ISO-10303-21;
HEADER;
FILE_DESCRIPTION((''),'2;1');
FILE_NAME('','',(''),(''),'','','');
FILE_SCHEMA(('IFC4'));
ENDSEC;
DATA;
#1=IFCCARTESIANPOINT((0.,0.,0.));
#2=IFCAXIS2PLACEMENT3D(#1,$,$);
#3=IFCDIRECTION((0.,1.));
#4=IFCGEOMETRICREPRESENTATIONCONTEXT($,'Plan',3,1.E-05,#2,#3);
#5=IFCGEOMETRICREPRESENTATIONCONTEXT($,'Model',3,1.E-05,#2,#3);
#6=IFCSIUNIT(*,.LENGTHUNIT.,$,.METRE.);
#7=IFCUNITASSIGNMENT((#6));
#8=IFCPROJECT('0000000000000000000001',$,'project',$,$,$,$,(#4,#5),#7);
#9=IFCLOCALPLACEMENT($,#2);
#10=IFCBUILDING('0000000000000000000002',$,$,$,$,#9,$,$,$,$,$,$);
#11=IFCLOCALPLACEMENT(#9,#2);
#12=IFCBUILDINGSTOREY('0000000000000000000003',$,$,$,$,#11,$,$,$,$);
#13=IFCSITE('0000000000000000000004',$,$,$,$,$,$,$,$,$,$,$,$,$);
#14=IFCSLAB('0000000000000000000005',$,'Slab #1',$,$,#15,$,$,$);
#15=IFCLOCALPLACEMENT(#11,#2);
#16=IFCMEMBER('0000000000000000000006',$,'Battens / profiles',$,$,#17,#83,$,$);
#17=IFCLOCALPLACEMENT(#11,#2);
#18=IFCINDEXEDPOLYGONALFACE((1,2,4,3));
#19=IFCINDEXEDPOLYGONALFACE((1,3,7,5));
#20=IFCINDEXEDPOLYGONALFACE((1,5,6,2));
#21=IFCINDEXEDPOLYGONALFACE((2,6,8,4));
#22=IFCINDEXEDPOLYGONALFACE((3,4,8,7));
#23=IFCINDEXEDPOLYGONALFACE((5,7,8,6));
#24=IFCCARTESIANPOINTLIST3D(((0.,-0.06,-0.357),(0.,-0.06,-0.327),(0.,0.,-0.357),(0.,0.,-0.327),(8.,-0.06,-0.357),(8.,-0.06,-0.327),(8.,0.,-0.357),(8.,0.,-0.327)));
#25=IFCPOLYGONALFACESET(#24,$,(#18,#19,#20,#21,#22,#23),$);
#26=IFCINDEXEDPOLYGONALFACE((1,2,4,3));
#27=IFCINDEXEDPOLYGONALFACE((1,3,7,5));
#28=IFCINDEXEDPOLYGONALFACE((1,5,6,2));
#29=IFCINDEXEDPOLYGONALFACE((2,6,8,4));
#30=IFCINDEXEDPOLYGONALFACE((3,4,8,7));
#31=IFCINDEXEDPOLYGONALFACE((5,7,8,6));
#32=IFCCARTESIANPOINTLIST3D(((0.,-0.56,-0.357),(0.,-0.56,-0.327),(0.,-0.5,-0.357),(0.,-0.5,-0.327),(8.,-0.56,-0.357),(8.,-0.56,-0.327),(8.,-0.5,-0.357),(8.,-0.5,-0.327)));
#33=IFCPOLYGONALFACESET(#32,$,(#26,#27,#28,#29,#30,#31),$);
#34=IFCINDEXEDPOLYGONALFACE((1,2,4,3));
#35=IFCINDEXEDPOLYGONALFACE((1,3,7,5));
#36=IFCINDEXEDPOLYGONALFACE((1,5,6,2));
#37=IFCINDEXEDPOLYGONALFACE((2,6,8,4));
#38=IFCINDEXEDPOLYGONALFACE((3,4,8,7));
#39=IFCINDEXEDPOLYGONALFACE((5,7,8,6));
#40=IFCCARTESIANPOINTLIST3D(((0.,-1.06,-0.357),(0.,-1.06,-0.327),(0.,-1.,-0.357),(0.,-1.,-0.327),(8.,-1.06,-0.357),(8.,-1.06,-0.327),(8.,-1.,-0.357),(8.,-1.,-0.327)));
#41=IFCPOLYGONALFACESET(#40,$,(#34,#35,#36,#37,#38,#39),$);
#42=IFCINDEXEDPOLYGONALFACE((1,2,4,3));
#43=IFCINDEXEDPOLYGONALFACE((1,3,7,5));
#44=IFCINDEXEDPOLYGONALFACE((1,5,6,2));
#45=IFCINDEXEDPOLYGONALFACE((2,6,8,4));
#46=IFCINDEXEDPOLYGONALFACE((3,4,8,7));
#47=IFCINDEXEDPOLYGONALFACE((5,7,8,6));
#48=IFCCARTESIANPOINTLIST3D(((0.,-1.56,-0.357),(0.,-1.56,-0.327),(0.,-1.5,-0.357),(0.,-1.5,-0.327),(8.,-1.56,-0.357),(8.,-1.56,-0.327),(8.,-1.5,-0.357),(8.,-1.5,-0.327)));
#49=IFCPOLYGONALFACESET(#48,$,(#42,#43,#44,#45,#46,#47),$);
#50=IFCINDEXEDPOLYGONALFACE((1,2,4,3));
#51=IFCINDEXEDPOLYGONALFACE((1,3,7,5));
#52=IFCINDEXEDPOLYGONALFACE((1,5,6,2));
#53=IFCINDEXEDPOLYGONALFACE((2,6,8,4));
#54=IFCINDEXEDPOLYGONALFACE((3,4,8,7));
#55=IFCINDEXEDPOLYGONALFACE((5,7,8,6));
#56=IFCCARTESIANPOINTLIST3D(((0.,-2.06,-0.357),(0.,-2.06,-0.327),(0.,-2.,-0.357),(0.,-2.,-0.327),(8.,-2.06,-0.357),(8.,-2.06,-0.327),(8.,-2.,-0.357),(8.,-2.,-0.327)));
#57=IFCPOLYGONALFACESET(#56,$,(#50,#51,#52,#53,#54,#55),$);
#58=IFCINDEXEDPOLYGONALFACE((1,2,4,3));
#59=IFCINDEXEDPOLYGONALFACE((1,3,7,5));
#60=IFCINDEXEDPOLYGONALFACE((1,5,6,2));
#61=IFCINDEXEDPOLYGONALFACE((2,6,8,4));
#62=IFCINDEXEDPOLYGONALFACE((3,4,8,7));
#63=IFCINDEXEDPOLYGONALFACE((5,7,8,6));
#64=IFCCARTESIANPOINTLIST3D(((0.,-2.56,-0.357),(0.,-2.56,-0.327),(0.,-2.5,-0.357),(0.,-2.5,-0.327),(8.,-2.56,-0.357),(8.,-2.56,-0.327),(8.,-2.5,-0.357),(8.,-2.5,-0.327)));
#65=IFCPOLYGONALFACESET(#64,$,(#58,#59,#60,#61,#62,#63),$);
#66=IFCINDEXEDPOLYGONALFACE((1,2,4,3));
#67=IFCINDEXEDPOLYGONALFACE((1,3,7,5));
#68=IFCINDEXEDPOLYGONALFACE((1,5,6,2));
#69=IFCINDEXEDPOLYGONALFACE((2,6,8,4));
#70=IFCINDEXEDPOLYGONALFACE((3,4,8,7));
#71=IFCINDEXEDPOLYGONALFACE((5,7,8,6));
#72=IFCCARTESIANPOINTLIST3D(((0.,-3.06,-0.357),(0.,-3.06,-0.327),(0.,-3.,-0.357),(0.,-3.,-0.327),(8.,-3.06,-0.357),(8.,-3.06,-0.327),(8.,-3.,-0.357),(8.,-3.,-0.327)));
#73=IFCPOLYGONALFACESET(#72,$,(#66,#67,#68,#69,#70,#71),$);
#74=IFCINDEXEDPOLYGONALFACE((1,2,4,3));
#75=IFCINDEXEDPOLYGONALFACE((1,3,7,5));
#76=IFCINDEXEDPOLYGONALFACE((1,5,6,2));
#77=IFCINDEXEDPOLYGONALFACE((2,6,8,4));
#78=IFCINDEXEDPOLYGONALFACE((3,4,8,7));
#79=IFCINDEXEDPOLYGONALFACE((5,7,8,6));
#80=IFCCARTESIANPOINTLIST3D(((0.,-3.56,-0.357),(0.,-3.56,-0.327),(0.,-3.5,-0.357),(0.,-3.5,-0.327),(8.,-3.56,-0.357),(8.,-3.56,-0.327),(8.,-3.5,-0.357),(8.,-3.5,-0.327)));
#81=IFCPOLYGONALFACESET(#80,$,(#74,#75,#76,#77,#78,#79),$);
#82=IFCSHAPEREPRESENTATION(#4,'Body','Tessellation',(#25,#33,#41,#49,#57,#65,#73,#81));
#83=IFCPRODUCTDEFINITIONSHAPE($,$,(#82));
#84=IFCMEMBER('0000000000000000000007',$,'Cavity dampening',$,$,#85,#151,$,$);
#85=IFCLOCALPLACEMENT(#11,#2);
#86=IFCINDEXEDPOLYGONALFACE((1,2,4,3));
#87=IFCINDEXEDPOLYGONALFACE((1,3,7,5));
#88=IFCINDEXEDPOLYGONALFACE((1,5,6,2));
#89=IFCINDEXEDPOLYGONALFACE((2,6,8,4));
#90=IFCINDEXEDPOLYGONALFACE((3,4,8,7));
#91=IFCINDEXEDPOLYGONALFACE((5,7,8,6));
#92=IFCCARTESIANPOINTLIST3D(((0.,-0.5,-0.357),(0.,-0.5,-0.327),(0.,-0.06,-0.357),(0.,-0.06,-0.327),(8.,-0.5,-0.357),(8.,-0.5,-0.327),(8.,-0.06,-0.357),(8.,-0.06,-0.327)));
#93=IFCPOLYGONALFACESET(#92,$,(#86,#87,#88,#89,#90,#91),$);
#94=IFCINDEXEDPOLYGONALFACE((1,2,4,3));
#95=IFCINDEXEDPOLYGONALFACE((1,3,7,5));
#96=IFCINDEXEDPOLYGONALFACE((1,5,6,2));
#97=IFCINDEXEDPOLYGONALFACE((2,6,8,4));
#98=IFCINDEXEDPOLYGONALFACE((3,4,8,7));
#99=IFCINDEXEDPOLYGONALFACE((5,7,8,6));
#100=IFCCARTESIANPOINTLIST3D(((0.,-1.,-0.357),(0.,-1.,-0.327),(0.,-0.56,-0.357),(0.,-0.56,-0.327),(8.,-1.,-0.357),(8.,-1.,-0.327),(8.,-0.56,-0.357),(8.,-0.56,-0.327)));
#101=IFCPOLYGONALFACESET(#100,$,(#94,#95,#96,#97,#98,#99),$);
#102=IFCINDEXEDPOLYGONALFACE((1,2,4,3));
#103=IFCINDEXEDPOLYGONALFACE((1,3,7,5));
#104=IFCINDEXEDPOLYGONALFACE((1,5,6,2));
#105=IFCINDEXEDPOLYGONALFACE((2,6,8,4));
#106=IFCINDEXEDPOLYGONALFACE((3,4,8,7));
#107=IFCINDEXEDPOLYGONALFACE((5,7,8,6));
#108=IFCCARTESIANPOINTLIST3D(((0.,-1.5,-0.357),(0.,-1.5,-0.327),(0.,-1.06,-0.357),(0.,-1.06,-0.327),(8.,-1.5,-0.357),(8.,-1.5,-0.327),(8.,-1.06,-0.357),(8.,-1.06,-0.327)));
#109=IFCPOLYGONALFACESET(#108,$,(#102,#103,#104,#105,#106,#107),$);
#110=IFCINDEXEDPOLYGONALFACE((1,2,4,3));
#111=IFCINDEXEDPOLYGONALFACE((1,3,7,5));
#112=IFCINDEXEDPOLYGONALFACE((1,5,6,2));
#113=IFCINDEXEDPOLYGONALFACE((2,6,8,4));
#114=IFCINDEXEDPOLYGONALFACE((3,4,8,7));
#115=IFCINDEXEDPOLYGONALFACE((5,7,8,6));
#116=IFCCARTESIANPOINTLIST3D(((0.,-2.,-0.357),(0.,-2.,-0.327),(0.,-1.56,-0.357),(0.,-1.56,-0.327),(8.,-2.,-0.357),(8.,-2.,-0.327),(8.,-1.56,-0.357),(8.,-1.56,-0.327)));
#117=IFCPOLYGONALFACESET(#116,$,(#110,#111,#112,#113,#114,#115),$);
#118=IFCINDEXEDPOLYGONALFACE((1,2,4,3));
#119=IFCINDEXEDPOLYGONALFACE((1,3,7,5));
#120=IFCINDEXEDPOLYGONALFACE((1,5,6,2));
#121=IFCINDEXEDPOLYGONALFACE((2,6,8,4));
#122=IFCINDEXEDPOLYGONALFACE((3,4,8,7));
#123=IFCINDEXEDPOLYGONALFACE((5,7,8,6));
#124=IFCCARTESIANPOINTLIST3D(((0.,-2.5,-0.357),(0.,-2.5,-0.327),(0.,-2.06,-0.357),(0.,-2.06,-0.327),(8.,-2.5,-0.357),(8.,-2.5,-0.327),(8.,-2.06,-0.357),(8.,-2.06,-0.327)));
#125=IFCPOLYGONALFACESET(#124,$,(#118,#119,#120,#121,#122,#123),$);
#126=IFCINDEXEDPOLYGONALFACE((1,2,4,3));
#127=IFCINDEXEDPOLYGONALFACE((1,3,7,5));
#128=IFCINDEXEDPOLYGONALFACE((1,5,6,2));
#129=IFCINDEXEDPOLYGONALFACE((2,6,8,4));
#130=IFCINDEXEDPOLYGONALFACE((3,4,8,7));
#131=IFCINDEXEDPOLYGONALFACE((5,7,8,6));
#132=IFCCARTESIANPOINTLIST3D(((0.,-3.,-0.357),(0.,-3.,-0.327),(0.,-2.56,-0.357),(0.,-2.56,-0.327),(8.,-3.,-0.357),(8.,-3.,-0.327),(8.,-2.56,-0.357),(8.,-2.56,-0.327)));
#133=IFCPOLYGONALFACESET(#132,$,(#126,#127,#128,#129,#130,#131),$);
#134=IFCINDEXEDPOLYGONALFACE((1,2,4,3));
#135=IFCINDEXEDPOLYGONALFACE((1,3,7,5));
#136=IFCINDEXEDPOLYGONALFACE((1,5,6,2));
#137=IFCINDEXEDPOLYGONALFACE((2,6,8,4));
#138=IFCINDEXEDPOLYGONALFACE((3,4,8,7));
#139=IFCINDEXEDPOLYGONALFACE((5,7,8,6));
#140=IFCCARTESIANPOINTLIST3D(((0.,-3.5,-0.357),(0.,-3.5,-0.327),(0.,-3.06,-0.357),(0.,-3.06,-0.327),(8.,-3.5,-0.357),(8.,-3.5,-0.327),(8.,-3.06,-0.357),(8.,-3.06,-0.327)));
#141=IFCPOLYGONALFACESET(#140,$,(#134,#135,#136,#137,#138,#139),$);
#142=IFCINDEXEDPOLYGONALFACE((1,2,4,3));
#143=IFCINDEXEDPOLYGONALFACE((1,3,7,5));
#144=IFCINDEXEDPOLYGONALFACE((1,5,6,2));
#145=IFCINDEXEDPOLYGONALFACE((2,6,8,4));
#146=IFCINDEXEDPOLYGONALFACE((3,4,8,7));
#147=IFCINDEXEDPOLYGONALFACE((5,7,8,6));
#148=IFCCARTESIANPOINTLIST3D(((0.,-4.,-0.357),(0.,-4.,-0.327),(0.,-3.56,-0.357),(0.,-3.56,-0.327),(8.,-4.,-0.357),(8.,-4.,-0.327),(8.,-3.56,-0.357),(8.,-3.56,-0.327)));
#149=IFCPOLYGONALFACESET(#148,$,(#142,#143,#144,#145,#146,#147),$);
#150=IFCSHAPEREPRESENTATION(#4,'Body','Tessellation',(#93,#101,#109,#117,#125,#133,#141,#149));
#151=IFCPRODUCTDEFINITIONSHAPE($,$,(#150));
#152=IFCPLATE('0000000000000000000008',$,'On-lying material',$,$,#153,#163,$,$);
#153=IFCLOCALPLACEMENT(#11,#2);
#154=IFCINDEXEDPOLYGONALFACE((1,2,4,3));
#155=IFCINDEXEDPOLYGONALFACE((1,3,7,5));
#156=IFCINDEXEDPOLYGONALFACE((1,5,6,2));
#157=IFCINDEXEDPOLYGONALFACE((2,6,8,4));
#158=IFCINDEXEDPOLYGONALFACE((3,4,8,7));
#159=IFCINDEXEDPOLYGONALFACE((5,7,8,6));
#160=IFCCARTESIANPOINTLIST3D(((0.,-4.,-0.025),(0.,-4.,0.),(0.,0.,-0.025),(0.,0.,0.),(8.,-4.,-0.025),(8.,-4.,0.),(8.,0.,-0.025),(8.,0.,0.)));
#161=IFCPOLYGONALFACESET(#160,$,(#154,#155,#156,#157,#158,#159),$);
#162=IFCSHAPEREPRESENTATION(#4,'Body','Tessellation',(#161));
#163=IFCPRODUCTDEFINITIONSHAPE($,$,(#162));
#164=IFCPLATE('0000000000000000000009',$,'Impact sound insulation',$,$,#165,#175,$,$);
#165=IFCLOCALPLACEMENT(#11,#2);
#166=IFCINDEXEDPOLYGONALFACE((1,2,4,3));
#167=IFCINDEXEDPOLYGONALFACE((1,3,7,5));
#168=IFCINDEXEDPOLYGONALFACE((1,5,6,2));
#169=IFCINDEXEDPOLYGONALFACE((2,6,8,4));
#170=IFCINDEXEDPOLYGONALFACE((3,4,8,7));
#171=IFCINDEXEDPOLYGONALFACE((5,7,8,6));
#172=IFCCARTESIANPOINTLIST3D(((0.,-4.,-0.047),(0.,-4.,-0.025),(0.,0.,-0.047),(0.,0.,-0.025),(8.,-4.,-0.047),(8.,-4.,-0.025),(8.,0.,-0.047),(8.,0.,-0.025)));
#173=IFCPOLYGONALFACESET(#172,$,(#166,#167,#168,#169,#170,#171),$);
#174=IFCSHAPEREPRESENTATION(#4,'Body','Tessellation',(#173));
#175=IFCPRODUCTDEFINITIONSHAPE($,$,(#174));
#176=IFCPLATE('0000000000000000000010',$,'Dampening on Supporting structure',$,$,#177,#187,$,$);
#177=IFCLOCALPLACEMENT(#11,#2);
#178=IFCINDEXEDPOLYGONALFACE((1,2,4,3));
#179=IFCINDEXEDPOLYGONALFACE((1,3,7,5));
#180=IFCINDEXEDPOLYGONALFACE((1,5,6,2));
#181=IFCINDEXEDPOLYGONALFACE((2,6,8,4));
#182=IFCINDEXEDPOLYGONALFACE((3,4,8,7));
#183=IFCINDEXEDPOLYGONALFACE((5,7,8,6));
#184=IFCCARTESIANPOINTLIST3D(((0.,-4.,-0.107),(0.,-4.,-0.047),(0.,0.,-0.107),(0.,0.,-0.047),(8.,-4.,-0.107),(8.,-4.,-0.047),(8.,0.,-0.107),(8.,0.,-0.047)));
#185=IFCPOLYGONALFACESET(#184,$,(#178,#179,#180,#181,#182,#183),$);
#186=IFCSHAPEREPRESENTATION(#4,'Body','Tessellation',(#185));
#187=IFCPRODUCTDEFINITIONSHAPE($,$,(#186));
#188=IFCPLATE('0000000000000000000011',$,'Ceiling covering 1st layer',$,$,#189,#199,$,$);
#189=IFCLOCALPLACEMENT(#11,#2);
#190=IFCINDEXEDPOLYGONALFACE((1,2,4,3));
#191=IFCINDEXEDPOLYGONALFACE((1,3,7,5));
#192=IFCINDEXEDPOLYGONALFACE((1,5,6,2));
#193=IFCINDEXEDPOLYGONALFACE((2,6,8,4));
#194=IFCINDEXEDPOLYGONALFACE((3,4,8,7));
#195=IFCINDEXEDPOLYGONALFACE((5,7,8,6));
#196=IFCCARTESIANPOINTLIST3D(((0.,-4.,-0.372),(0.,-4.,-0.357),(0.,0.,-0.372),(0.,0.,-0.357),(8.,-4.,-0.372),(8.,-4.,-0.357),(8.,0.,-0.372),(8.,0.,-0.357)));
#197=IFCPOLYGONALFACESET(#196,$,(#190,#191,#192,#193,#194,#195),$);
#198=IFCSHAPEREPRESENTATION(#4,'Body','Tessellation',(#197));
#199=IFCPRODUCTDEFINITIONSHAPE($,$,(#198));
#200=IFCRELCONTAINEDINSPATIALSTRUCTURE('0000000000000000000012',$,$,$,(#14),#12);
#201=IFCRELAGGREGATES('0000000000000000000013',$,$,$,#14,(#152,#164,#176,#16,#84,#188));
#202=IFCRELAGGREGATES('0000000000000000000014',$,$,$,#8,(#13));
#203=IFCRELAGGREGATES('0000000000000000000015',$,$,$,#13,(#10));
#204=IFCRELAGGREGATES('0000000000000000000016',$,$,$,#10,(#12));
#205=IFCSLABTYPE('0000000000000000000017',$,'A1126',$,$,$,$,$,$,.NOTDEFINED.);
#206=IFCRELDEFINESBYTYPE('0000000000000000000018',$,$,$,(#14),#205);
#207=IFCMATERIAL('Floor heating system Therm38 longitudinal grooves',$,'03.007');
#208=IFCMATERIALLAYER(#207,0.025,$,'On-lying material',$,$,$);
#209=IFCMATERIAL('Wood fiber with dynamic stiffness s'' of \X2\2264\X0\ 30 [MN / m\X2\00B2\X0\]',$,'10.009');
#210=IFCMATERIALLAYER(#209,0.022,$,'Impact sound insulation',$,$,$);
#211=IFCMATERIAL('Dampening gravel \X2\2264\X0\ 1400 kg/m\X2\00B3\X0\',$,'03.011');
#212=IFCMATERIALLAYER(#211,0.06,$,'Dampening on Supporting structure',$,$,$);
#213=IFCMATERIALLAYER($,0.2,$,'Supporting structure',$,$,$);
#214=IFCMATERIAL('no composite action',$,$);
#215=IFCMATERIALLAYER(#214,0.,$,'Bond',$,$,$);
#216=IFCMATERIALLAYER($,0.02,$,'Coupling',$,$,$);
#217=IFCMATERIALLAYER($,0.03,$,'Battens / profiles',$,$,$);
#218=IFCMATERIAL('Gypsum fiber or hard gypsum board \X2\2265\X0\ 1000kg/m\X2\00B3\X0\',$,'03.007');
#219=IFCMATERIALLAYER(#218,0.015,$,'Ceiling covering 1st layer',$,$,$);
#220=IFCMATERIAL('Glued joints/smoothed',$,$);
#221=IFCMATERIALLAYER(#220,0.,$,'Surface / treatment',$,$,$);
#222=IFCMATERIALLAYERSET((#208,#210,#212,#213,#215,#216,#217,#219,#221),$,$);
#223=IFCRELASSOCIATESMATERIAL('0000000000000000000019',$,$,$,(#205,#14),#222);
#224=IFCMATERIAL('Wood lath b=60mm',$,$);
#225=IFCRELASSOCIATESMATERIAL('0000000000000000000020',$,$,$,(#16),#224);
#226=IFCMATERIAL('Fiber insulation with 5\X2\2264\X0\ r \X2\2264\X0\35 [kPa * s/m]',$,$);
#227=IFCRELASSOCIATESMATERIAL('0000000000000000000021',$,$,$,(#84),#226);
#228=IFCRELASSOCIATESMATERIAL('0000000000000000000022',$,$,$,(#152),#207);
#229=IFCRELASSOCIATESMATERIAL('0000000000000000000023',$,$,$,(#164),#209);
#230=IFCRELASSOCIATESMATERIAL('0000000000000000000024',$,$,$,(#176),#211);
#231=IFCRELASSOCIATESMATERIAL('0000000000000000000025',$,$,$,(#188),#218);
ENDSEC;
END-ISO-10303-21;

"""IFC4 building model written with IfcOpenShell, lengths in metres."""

from ifc_helpers import new_model, si_unit, direction, frame, frame_2d, origin, origin_with_axes, place, context, project, spatial, rectangle, extrude, material, layer, layer_set, type_object, element, aggregate, save


model = new_model("IFC4")

# Units and contexts
plan_context = context("Plan", 3, precision=1e-05, world=origin(), true_north=direction((0.0, 1.0)))
model_context = context("Model", 3, precision=1e-05, world=origin(), true_north=direction((0.0, 1.0)))
ifc_project = project(units=[si_unit("LENGTHUNIT", "METRE")], contexts=[plan_context, model_context])

# Site, building, storey
site = spatial("IfcSite", under=ifc_project)
building_placement = place(None, origin())
building = spatial("IfcBuilding", under=site, at=building_placement)
storey_placement = place(building_placement, origin())
storey = spatial("IfcBuildingStorey", under=building, at=storey_placement)

# Slab, members, plates
ifc_material_1 = material(Name="Floor heating system Therm38 longitudinal grooves", Category="03.007")
ifc_layer_1 = layer(ifc_material_1, 0.025, Name="On-lying material")
ifc_material_2 = material(Name="Wood fiber with dynamic stiffness s' of ≤ 30 [MN / m²]", Category="10.009")
ifc_layer_2 = layer(ifc_material_2, 0.022, Name="Impact sound insulation")
ifc_material_3 = material(Name="Dampening gravel ≤ 1400 kg/m³", Category="03.011")
ifc_layer_3 = layer(ifc_material_3, 0.06, Name="Dampening on Supporting structure")
ifc_layer_4 = layer(None, 0.2, Name="Supporting structure")
ifc_material_4 = material(Name="no composite action")
ifc_layer_5 = layer(ifc_material_4, 0.0, Name="Bond")
ifc_layer_6 = layer(None, 0.02, Name="Coupling")
ifc_layer_7 = layer(None, 0.03, Name="Battens / profiles")
ifc_material_5 = material(Name="Gypsum fiber or hard gypsum board ≥ 1000kg/m³", Category="03.007")
ifc_layer_8 = layer(ifc_material_5, 0.015, Name="Ceiling covering 1st layer")
ifc_material_6 = material(Name="Glued joints/smoothed")
ifc_layer_9 = layer(ifc_material_6, 0.0, Name="Surface / treatment")
ifc_layer_set = layer_set([ifc_layer_1, ifc_layer_2, ifc_layer_3, ifc_layer_4, ifc_layer_5, ifc_layer_6, ifc_layer_7, ifc_layer_8, ifc_layer_9])
slab_type = type_object("IfcSlabType", Name="A1126", PredefinedType="NOTDEFINED", material=ifc_layer_set)
slab_placement = place(None, frame((0.0, 0.0, 0.0), z_axis=(0.0, 0.0, -1.0), x_axis=(1.0, 0.0, 0.0)))
slab = element("IfcSlab", 1, at=slab_placement, inside=storey, type_object=slab_type, material=ifc_layer_set, Name="Slab #1")
ifc_material_7 = material(Name="Wood lath b=60mm")
member_1_placement = place(slab_placement, origin())
member_1 = element("IfcMember", 2, at=member_1_placement, material=ifc_material_7, Name="Battens / profiles", context=plan_context, shape_type="SweptSolid", body=[
    extrude(rectangle(XDim=0.06, YDim=0.03, at=frame_2d((0.03, 0.015), x_axis=(1.0, 0.0))), frame((0.0, 0.0, 0.327), z_axis=(1.0, 0.0, 0.0), x_axis=(0.0, 1.0, 0.0)), (0.0, 0.0, 1.0), 8.0),
    extrude(rectangle(XDim=0.06, YDim=0.03, at=frame_2d((0.03, 0.015), x_axis=(1.0, 0.0))), frame((0.0, 0.5, 0.327), z_axis=(1.0, 0.0, 0.0), x_axis=(0.0, 1.0, 0.0)), (0.0, 0.0, 1.0), 8.0),
    extrude(rectangle(XDim=0.06, YDim=0.03, at=frame_2d((0.03, 0.015), x_axis=(1.0, 0.0))), frame((0.0, 1.0, 0.327), z_axis=(1.0, 0.0, 0.0), x_axis=(0.0, 1.0, 0.0)), (0.0, 0.0, 1.0), 8.0),
    extrude(rectangle(XDim=0.06, YDim=0.03, at=frame_2d((0.03, 0.015), x_axis=(1.0, 0.0))), frame((0.0, 1.5, 0.327), z_axis=(1.0, 0.0, 0.0), x_axis=(0.0, 1.0, 0.0)), (0.0, 0.0, 1.0), 8.0),
    extrude(rectangle(XDim=0.06, YDim=0.03, at=frame_2d((0.03, 0.015), x_axis=(1.0, 0.0))), frame((0.0, 2.0, 0.327), z_axis=(1.0, 0.0, 0.0), x_axis=(0.0, 1.0, 0.0)), (0.0, 0.0, 1.0), 8.0),
    extrude(rectangle(XDim=0.06, YDim=0.03, at=frame_2d((0.03, 0.015), x_axis=(1.0, 0.0))), frame((0.0, 2.5, 0.327), z_axis=(1.0, 0.0, 0.0), x_axis=(0.0, 1.0, 0.0)), (0.0, 0.0, 1.0), 8.0),
    extrude(rectangle(XDim=0.06, YDim=0.03, at=frame_2d((0.03, 0.015), x_axis=(1.0, 0.0))), frame((0.0, 3.0, 0.327), z_axis=(1.0, 0.0, 0.0), x_axis=(0.0, 1.0, 0.0)), (0.0, 0.0, 1.0), 8.0),
    extrude(rectangle(XDim=0.06, YDim=0.03, at=frame_2d((0.03, 0.015), x_axis=(1.0, 0.0))), frame((0.0, 3.5, 0.327), z_axis=(1.0, 0.0, 0.0), x_axis=(0.0, 1.0, 0.0)), (0.0, 0.0, 1.0), 8.0),
])
ifc_material_8 = material(Name="Fiber insulation with 5≤ r ≤35 [kPa * s/m]")
member_2_placement = place(slab_placement, origin())
member_2 = element("IfcMember", 3, at=member_2_placement, material=ifc_material_8, Name="Cavity dampening", context=plan_context, shape_type="SweptSolid", body=[
    extrude(rectangle(XDim=0.44, YDim=0.03, at=frame_2d((0.22, 0.015), x_axis=(1.0, 0.0))), frame((0.0, 0.06, 0.327), z_axis=(1.0, 0.0, 0.0), x_axis=(0.0, 1.0, 0.0)), (0.0, 0.0, 1.0), 8.0),
    extrude(rectangle(XDim=0.44, YDim=0.03, at=frame_2d((0.22, 0.015), x_axis=(1.0, 0.0))), frame((0.0, 0.56, 0.327), z_axis=(1.0, 0.0, 0.0), x_axis=(0.0, 1.0, 0.0)), (0.0, 0.0, 1.0), 8.0),
    extrude(rectangle(XDim=0.44, YDim=0.03, at=frame_2d((0.22, 0.015), x_axis=(1.0, 0.0))), frame((0.0, 1.06, 0.327), z_axis=(1.0, 0.0, 0.0), x_axis=(0.0, 1.0, 0.0)), (0.0, 0.0, 1.0), 8.0),
    extrude(rectangle(XDim=0.44, YDim=0.03, at=frame_2d((0.22, 0.015), x_axis=(1.0, 0.0))), frame((0.0, 1.56, 0.327), z_axis=(1.0, 0.0, 0.0), x_axis=(0.0, 1.0, 0.0)), (0.0, 0.0, 1.0), 8.0),
    extrude(rectangle(XDim=0.44, YDim=0.03, at=frame_2d((0.22, 0.015), x_axis=(1.0, 0.0))), frame((0.0, 2.06, 0.327), z_axis=(1.0, 0.0, 0.0), x_axis=(0.0, 1.0, 0.0)), (0.0, 0.0, 1.0), 8.0),
    extrude(rectangle(XDim=0.44, YDim=0.03, at=frame_2d((0.22, 0.015), x_axis=(1.0, 0.0))), frame((0.0, 2.56, 0.327), z_axis=(1.0, 0.0, 0.0), x_axis=(0.0, 1.0, 0.0)), (0.0, 0.0, 1.0), 8.0),
    extrude(rectangle(XDim=0.44, YDim=0.03, at=frame_2d((0.22, 0.015), x_axis=(1.0, 0.0))), frame((0.0, 3.06, 0.327), z_axis=(1.0, 0.0, 0.0), x_axis=(0.0, 1.0, 0.0)), (0.0, 0.0, 1.0), 8.0),
    extrude(rectangle(XDim=0.44, YDim=0.03, at=frame_2d((0.22, 0.015), x_axis=(1.0, 0.0))), frame((0.0, 3.56, 0.327), z_axis=(1.0, 0.0, 0.0), x_axis=(0.0, 1.0, 0.0)), (0.0, 0.0, 1.0), 8.0),
])
plate_1_placement = place(slab_placement, origin())
plate_1 = element("IfcPlate", 4, at=plate_1_placement, material=ifc_material_1, Name="On-lying material", context=plan_context, shape_type="SweptSolid", body=[
    extrude(rectangle(XDim=8.0, YDim=4.0, at=frame_2d((4.0, 2.0), x_axis=(1.0, 0.0))), origin_with_axes(), (0.0, 0.0, 1.0), 0.025),
])
plate_2_placement = place(slab_placement, origin())
plate_2 = element("IfcPlate", 5, at=plate_2_placement, material=ifc_material_2, Name="Impact sound insulation", context=plan_context, shape_type="SweptSolid", body=[
    extrude(rectangle(XDim=8.0, YDim=4.0, at=frame_2d((4.0, 2.0), x_axis=(1.0, 0.0))), frame((0.0, 0.0, 0.025), z_axis=(0.0, 0.0, 1.0), x_axis=(1.0, 0.0, 0.0)), (0.0, 0.0, 1.0), 0.022),
])
plate_3_placement = place(slab_placement, origin())
plate_3 = element("IfcPlate", 6, at=plate_3_placement, material=ifc_material_3, Name="Dampening on Supporting structure", context=plan_context, shape_type="SweptSolid", body=[
    extrude(rectangle(XDim=8.0, YDim=4.0, at=frame_2d((4.0, 2.0), x_axis=(1.0, 0.0))), frame((0.0, 0.0, 0.047), z_axis=(0.0, 0.0, 1.0), x_axis=(1.0, 0.0, 0.0)), (0.0, 0.0, 1.0), 0.06),
])
plate_4_placement = place(slab_placement, origin())
plate_4 = element("IfcPlate", 7, at=plate_4_placement, material=ifc_material_5, Name="Ceiling covering 1st layer", context=plan_context, shape_type="SweptSolid", body=[
    extrude(rectangle(XDim=8.0, YDim=4.0, at=frame_2d((4.0, 2.0), x_axis=(1.0, 0.0))), frame((0.0, 0.0, 0.357), z_axis=(0.0, 0.0, 1.0), x_axis=(1.0, 0.0, 0.0)), (0.0, 0.0, 1.0), 0.015),
])
aggregate(slab, [plate_1, plate_2, plate_3, member_1, member_2, plate_4])

save(model, "model.ifc")
